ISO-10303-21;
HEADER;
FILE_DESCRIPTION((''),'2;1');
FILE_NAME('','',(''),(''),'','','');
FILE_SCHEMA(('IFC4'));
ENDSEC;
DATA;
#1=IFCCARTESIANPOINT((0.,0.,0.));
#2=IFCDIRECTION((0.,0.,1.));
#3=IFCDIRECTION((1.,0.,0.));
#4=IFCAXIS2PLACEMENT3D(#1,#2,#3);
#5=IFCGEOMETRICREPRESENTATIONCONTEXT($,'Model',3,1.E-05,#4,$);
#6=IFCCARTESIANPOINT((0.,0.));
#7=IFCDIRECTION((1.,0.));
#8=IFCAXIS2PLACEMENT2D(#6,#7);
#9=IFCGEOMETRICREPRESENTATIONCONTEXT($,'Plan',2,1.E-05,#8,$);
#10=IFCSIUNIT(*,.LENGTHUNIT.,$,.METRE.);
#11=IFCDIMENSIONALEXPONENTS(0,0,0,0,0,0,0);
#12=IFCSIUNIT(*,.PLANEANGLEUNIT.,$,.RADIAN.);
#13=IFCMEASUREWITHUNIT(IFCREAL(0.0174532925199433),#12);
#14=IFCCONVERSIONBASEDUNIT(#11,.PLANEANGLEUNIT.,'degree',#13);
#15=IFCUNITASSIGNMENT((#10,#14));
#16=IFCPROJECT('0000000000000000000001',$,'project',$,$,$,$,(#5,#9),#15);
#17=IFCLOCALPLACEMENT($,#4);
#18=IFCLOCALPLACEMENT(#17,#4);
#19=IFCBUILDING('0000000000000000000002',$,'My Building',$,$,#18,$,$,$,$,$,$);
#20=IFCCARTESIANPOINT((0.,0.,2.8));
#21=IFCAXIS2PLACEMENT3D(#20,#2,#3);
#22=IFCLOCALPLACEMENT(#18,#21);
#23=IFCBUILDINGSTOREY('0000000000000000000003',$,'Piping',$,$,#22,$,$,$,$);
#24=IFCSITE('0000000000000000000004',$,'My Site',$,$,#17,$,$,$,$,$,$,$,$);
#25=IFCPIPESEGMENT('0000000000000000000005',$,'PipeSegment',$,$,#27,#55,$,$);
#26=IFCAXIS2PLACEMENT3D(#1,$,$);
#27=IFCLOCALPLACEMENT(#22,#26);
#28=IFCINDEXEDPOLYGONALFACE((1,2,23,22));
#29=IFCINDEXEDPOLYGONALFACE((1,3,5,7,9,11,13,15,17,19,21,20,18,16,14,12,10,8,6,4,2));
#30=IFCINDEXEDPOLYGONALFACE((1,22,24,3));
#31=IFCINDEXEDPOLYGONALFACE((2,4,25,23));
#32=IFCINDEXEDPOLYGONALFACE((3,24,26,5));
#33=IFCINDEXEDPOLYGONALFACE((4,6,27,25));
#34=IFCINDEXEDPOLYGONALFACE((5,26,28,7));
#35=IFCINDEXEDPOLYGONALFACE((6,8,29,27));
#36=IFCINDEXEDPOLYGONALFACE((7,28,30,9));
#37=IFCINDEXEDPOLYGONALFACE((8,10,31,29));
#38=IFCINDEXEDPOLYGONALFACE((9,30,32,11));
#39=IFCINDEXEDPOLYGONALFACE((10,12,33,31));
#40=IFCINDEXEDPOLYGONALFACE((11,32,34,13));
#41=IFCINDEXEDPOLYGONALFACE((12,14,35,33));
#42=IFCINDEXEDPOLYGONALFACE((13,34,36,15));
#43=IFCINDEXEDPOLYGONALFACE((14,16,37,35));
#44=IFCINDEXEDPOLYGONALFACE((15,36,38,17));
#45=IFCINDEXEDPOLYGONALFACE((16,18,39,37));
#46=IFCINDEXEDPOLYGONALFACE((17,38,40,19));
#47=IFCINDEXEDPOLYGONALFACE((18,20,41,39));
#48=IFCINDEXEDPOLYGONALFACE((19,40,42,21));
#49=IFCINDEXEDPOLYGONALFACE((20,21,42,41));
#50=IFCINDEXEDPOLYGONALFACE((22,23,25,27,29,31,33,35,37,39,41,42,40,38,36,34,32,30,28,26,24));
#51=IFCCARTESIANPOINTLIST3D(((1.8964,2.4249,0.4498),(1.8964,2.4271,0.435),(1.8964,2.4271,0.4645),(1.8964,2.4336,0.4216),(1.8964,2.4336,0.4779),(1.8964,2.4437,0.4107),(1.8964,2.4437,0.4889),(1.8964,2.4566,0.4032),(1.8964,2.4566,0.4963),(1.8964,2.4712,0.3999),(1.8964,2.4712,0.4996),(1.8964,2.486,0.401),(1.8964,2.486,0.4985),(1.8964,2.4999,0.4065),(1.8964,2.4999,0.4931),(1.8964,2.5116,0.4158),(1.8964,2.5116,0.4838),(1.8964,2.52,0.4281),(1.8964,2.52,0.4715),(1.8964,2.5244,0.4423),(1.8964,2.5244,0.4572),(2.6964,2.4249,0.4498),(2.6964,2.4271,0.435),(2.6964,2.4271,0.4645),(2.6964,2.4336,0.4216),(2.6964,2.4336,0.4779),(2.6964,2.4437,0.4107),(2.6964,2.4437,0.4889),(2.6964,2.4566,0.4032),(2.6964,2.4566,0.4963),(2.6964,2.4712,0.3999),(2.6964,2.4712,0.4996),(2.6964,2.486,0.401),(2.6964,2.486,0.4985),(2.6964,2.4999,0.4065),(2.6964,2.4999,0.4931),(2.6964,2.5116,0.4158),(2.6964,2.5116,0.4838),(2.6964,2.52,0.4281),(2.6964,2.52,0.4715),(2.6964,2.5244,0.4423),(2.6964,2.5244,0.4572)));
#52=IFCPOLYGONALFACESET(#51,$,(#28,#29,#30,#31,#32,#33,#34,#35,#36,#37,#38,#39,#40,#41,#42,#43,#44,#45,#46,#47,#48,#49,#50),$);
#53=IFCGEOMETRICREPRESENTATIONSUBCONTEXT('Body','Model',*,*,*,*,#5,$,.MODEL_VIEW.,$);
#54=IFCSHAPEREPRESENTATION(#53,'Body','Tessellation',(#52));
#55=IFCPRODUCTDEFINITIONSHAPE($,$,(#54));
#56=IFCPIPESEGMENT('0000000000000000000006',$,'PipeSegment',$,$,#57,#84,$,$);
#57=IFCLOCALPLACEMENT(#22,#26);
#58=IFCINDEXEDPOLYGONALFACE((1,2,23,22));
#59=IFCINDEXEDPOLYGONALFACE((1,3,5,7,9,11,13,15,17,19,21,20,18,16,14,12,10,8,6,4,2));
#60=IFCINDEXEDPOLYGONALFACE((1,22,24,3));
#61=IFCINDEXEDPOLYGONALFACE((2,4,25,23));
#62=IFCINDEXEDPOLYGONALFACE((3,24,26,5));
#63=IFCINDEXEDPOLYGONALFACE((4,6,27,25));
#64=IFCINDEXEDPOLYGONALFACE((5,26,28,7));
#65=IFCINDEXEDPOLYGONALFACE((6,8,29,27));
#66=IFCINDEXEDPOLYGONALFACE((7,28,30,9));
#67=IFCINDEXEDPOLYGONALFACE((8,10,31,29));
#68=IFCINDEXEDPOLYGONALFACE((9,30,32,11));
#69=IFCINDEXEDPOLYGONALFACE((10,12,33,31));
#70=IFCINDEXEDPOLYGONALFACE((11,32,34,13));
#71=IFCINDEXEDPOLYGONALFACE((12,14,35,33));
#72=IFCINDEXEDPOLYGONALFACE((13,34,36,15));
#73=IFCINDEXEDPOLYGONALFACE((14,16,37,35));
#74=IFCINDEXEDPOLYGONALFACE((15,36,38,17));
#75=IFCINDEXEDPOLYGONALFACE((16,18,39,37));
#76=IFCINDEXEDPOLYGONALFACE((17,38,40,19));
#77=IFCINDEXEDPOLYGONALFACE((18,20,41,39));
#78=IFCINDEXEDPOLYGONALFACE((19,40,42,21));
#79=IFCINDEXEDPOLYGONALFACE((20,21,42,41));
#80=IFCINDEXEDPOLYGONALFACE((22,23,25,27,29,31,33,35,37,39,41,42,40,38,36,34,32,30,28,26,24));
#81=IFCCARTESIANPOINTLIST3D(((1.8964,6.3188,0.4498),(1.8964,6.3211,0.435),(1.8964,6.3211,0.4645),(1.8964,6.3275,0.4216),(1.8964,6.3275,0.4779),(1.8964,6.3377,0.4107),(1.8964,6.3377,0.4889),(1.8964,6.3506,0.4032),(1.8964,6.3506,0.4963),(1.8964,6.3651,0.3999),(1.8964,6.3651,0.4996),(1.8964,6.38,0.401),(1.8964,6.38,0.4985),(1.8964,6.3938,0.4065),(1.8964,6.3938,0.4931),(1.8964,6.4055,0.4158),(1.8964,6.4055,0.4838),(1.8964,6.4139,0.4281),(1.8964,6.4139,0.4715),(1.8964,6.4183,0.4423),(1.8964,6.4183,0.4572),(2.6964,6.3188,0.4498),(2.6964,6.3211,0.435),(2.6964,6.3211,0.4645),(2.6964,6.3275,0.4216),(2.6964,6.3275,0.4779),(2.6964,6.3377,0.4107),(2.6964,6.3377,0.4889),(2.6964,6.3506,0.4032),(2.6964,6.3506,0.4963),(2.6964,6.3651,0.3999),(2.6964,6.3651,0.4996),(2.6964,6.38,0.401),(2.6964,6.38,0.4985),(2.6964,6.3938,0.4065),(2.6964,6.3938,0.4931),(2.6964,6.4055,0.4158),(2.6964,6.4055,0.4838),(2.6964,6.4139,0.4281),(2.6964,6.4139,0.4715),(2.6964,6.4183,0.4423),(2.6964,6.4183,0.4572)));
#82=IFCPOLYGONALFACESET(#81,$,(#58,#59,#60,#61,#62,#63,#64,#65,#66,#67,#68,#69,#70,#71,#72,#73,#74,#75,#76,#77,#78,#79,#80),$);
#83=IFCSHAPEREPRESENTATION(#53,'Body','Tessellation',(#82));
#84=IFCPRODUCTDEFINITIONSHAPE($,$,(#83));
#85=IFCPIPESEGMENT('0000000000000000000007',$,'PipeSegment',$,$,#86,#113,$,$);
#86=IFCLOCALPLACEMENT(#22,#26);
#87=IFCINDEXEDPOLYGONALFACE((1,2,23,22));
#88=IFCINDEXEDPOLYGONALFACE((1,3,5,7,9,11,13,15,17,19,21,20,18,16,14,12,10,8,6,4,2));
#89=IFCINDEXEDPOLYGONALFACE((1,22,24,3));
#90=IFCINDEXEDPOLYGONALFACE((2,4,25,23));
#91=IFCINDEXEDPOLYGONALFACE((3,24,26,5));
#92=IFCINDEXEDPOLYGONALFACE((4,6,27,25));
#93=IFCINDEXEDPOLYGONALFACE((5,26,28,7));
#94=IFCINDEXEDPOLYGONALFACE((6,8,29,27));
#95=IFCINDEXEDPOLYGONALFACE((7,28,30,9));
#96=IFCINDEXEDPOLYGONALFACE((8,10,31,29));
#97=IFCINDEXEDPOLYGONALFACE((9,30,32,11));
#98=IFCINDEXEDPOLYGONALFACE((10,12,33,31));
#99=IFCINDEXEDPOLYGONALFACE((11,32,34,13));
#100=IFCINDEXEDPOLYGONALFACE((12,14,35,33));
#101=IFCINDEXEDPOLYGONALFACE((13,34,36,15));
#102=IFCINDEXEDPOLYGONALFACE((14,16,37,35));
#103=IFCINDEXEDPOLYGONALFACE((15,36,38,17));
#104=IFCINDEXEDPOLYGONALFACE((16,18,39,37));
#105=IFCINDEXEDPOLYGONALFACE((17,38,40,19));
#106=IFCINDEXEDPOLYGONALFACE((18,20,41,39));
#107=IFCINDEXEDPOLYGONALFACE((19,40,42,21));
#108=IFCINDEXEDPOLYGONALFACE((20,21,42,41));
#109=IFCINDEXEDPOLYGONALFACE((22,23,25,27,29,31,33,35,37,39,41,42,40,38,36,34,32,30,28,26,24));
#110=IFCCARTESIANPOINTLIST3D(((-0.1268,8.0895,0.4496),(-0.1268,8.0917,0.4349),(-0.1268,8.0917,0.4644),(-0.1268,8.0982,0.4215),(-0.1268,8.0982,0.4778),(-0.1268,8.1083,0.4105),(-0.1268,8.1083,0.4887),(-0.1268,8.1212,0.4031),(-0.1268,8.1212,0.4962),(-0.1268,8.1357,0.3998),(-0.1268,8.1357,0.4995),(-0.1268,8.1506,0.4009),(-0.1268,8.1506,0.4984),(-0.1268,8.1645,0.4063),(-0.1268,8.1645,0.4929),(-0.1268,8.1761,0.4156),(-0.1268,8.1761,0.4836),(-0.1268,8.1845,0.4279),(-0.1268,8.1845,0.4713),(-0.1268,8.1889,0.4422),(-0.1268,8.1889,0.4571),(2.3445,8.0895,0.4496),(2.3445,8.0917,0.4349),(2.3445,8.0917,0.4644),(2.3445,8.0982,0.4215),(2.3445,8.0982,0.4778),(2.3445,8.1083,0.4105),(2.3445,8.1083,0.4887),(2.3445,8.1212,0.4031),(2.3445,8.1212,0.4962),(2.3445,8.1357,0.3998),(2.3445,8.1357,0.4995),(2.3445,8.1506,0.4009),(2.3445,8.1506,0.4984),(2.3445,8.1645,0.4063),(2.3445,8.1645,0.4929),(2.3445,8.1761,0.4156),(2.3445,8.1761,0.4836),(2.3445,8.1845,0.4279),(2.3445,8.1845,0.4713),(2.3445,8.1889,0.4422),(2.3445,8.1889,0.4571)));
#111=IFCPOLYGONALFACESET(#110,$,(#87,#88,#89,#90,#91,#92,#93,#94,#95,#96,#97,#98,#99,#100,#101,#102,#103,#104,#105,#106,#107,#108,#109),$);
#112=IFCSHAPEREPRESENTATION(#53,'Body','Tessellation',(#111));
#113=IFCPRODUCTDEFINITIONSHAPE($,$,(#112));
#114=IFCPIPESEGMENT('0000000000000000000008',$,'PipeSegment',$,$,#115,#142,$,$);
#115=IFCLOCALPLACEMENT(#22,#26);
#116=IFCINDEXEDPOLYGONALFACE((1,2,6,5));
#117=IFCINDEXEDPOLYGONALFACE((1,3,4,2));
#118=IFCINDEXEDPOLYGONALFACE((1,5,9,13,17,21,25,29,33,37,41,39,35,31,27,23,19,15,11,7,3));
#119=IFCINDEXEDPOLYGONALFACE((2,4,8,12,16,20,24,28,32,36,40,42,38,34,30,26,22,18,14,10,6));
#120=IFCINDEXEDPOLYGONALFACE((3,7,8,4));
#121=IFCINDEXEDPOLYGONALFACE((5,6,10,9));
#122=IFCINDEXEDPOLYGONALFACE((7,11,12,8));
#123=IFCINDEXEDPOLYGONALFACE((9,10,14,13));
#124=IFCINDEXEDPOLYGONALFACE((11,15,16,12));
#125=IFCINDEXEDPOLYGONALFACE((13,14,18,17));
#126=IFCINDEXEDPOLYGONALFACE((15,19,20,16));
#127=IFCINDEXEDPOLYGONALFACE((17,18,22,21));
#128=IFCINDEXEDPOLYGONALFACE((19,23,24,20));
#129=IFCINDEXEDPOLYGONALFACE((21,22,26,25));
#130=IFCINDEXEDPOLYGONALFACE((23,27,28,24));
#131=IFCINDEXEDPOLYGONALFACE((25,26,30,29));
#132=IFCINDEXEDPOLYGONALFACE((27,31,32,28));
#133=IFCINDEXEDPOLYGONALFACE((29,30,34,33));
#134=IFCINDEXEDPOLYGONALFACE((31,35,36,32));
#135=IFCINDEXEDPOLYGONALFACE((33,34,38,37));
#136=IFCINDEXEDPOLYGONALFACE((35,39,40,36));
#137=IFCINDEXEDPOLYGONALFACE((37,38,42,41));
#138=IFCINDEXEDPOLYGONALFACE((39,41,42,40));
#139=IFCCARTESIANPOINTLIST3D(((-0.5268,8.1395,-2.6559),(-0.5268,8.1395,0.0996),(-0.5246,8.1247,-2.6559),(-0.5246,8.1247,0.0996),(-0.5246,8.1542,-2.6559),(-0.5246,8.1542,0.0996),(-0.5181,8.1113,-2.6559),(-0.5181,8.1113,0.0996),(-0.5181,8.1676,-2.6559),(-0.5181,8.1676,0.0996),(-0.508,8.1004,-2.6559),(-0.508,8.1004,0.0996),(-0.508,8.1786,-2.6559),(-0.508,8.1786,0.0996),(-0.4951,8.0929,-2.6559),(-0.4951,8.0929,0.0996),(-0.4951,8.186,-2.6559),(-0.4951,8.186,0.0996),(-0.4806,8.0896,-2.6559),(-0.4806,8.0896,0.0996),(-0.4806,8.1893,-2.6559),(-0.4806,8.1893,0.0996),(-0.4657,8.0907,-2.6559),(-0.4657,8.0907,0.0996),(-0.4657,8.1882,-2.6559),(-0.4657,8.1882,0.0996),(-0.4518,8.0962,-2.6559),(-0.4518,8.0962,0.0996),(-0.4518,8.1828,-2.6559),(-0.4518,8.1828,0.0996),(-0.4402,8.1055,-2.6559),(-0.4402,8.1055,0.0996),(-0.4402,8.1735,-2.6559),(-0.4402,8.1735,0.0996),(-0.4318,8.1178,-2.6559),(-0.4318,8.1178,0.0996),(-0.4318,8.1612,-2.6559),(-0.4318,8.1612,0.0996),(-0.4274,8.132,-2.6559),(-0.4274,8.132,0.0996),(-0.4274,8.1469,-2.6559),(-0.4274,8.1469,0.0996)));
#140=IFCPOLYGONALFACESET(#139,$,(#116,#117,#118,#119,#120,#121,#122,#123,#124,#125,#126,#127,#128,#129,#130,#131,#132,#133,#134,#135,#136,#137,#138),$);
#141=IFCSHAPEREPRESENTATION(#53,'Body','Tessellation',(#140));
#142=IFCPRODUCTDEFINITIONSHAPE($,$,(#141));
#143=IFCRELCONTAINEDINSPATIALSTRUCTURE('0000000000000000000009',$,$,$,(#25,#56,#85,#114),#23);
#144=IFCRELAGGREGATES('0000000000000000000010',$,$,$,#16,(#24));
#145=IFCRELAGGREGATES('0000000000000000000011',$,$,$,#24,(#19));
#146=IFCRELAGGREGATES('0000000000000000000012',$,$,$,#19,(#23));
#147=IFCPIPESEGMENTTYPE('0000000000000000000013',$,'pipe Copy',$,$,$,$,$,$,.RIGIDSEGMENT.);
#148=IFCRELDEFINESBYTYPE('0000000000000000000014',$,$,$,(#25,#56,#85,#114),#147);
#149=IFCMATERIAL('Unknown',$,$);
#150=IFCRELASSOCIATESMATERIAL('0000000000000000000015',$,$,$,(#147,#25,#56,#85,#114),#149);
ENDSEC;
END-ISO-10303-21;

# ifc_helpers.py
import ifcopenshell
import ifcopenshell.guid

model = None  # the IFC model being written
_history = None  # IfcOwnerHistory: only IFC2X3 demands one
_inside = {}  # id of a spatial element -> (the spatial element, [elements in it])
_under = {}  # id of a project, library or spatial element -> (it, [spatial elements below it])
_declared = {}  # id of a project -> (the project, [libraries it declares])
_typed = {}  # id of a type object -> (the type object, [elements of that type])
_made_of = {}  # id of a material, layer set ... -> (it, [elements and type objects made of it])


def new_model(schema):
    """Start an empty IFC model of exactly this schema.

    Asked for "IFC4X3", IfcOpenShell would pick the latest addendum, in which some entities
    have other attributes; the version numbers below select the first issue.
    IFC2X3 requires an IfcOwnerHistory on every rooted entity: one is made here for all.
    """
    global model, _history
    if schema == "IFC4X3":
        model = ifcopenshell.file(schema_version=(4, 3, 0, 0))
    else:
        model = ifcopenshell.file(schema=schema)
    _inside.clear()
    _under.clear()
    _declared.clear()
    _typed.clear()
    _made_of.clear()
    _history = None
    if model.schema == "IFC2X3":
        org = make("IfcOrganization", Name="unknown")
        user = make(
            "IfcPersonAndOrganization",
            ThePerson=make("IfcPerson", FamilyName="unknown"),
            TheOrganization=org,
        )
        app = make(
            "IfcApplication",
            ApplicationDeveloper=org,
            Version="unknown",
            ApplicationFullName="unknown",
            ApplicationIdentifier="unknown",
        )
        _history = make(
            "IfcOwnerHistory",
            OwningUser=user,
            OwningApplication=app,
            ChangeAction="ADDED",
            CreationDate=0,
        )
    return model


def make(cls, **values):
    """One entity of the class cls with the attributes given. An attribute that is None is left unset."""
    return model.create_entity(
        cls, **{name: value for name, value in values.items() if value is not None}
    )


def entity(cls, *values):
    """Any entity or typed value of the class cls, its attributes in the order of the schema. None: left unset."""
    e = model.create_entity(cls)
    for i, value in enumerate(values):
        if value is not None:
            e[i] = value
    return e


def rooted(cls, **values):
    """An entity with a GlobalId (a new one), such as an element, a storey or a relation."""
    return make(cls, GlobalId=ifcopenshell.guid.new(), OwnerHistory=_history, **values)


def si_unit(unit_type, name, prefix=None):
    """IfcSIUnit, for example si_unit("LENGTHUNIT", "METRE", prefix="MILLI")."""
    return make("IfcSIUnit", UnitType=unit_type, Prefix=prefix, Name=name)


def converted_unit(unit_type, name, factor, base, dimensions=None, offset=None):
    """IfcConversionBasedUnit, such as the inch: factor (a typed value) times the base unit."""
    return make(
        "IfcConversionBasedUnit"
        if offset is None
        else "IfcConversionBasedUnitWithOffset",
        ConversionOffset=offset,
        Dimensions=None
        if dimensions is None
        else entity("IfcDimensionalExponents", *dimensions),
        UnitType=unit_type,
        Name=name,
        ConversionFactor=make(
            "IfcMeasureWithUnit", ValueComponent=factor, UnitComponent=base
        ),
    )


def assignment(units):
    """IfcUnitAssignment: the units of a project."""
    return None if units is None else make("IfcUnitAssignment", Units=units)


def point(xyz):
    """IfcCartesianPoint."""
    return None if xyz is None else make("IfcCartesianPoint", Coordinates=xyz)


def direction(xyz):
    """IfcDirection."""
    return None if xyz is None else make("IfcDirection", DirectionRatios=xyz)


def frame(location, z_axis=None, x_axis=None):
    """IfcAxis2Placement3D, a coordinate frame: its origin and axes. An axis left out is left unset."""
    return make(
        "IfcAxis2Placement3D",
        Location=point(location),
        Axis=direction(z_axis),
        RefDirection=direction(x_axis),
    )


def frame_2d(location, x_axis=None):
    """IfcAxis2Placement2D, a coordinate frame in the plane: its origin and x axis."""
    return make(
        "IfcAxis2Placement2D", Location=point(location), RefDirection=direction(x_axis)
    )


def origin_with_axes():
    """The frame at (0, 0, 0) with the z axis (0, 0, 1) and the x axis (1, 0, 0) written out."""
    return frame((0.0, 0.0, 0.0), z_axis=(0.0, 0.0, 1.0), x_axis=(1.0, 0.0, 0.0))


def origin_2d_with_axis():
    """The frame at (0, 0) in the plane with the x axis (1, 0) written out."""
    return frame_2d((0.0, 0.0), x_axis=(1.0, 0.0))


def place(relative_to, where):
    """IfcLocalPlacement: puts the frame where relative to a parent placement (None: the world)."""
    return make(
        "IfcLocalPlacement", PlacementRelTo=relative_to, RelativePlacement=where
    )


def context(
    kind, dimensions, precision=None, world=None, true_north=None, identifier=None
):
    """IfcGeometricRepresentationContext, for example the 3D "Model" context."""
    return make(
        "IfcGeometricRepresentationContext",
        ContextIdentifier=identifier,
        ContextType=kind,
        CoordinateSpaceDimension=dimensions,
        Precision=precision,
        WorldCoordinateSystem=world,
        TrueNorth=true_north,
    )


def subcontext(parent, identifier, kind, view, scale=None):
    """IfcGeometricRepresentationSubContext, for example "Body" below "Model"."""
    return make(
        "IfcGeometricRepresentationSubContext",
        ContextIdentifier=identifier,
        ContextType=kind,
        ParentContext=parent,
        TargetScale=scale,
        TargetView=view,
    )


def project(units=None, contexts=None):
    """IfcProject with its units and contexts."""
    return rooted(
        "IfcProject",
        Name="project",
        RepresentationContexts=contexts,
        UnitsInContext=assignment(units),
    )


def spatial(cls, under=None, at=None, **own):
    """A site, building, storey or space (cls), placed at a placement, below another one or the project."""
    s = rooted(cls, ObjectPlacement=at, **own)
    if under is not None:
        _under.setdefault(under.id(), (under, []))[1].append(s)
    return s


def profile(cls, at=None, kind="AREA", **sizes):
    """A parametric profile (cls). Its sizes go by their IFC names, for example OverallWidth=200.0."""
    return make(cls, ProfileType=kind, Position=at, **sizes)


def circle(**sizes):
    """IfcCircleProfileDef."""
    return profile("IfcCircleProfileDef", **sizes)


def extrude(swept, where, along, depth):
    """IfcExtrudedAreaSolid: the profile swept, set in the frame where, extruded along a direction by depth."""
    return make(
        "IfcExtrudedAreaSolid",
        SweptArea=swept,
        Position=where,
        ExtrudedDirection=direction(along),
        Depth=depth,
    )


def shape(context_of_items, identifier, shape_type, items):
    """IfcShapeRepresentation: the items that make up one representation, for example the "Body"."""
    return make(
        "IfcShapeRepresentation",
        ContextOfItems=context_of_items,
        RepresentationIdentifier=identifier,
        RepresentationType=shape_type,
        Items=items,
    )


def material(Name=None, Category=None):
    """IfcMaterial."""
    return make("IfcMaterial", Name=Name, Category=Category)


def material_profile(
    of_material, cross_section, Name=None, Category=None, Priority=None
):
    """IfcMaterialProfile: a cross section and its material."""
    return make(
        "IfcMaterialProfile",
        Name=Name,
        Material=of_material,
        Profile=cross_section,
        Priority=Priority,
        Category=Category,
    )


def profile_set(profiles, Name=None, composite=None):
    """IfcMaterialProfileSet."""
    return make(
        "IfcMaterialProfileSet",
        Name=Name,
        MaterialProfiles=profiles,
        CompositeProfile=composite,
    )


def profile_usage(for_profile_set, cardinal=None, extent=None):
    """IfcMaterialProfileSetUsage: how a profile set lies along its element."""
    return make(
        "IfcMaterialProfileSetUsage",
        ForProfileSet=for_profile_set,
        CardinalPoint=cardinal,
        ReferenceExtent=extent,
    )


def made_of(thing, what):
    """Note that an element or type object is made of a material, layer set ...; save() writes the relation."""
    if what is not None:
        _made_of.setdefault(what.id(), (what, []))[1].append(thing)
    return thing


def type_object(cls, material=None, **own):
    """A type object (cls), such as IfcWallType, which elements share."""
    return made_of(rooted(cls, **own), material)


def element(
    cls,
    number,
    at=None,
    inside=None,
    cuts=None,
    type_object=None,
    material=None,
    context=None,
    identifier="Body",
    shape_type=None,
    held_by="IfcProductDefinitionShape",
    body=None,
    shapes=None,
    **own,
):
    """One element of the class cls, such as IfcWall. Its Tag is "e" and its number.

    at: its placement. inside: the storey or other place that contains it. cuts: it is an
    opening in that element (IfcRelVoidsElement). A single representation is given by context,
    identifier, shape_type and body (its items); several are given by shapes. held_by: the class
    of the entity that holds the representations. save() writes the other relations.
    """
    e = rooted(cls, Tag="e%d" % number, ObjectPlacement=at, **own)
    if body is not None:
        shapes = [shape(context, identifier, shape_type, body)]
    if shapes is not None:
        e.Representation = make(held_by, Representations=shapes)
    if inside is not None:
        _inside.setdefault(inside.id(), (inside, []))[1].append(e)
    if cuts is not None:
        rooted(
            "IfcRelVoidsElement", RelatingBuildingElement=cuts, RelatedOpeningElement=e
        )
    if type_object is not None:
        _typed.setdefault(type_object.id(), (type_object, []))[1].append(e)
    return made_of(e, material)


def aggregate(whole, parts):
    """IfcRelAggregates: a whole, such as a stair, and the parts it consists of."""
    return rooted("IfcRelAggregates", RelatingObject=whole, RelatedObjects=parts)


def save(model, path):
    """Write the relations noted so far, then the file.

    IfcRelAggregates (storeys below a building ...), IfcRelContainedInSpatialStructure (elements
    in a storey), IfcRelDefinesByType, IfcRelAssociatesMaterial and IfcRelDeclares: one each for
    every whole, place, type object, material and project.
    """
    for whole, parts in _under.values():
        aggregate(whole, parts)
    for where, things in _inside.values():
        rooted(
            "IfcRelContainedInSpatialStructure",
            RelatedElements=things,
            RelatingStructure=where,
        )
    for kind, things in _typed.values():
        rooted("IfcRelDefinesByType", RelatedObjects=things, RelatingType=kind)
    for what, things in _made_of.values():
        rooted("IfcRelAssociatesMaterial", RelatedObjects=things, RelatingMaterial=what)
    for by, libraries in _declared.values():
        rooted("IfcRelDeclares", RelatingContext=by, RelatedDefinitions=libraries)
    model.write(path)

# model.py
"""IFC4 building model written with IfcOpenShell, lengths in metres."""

from ifc_helpers import new_model, entity, si_unit, converted_unit, frame, origin_with_axes, origin_2d_with_axis, place, context, subcontext, project, spatial, circle, extrude, material, material_profile, profile_set, profile_usage, type_object, element, save


model = new_model("IFC4")

# Units and contexts
model_context = context("Model", 3, precision=1e-05, world=origin_with_axes())
plan_context = context("Plan", 2, precision=1e-05, world=origin_2d_with_axis())
body_context = subcontext(model_context, "Body", "Model", "MODEL_VIEW")
ifc_project = project(units=[si_unit("LENGTHUNIT", "METRE"), converted_unit("PLANEANGLEUNIT", "degree", entity("IfcReal", 0.0174532925199433), si_unit("PLANEANGLEUNIT", "RADIAN"), dimensions=[0, 0, 0, 0, 0, 0, 0])], contexts=[model_context, plan_context])

# Site, building, storey
site_placement = place(None, origin_with_axes())
site = spatial("IfcSite", under=ifc_project, at=site_placement, Name="My Site")
building_placement = place(site_placement, origin_with_axes())
building = spatial("IfcBuilding", under=site, at=building_placement, Name="My Building")
storey_placement = place(building_placement, frame((0.0, 0.0, 2.8), z_axis=(0.0, 0.0, 1.0), x_axis=(1.0, 0.0, 0.0)))
storey = spatial("IfcBuildingStorey", under=building, at=storey_placement, Name="Piping")

# Pipe segments
ifc_material = material(Name="Unknown")
ifc_material_profile = material_profile(ifc_material, circle(Radius=0.05))
ifc_profile_set = profile_set([ifc_material_profile])
pipe_segment_type = type_object("IfcPipeSegmentType", Name="pipe Copy", PredefinedType="RIGIDSEGMENT", material=ifc_profile_set)
ifc_profile_usage_1 = profile_usage(ifc_profile_set, cardinal=5)
pipe_segment_1_placement = place(storey_placement, frame((2.6964, 2.4749, 0.4498), z_axis=(-1.0, 0.0, 0.0), x_axis=(0.0, -1.0, 0.0)))
element("IfcPipeSegment", 1, at=pipe_segment_1_placement, inside=storey, type_object=pipe_segment_type, material=ifc_profile_usage_1, Name="PipeSegment", context=body_context, shape_type="SweptSolid", body=[
    extrude(circle(Radius=0.05), origin_with_axes(), (0.0, 0.0, 1.0), 0.8),
])
ifc_profile_usage_2 = profile_usage(ifc_profile_set, cardinal=5)
pipe_segment_2_placement = place(storey_placement, frame((2.6964, 6.3688, 0.4498), z_axis=(-1.0, 0.0, 0.0), x_axis=(0.0, -1.0, 0.0)))
element("IfcPipeSegment", 2, at=pipe_segment_2_placement, inside=storey, type_object=pipe_segment_type, material=ifc_profile_usage_2, Name="PipeSegment", context=body_context, shape_type="SweptSolid", body=[
    extrude(circle(Radius=0.05), origin_with_axes(), (0.0, 0.0, 1.0), 0.8),
])
ifc_profile_usage_3 = profile_usage(ifc_profile_set, cardinal=5)
pipe_segment_3_placement = place(storey_placement, frame((2.3445, 8.1395, 0.4496), z_axis=(-1.0, 0.0, 0.0), x_axis=(0.0, -1.0, 0.0)))
element("IfcPipeSegment", 3, at=pipe_segment_3_placement, inside=storey, type_object=pipe_segment_type, material=ifc_profile_usage_3, Name="PipeSegment", context=body_context, shape_type="SweptSolid", body=[
    extrude(circle(Radius=0.05), origin_with_axes(), (0.0, 0.0, 1.0), 2.4713),
])
ifc_profile_usage_4 = profile_usage(ifc_profile_set, cardinal=5)
pipe_segment_4_placement = place(storey_placement, frame((-0.4768, 8.1395, 0.0996), z_axis=(0.0, 0.0, -1.0), x_axis=(-1.0, 0.0, 0.0)))
element("IfcPipeSegment", 4, at=pipe_segment_4_placement, inside=storey, type_object=pipe_segment_type, material=ifc_profile_usage_4, Name="PipeSegment", context=body_context, shape_type="SweptSolid", body=[
    extrude(circle(Radius=0.05), origin_with_axes(), (0.0, 0.0, 1.0), 2.7556),
])

save(model, "model.ifc")
